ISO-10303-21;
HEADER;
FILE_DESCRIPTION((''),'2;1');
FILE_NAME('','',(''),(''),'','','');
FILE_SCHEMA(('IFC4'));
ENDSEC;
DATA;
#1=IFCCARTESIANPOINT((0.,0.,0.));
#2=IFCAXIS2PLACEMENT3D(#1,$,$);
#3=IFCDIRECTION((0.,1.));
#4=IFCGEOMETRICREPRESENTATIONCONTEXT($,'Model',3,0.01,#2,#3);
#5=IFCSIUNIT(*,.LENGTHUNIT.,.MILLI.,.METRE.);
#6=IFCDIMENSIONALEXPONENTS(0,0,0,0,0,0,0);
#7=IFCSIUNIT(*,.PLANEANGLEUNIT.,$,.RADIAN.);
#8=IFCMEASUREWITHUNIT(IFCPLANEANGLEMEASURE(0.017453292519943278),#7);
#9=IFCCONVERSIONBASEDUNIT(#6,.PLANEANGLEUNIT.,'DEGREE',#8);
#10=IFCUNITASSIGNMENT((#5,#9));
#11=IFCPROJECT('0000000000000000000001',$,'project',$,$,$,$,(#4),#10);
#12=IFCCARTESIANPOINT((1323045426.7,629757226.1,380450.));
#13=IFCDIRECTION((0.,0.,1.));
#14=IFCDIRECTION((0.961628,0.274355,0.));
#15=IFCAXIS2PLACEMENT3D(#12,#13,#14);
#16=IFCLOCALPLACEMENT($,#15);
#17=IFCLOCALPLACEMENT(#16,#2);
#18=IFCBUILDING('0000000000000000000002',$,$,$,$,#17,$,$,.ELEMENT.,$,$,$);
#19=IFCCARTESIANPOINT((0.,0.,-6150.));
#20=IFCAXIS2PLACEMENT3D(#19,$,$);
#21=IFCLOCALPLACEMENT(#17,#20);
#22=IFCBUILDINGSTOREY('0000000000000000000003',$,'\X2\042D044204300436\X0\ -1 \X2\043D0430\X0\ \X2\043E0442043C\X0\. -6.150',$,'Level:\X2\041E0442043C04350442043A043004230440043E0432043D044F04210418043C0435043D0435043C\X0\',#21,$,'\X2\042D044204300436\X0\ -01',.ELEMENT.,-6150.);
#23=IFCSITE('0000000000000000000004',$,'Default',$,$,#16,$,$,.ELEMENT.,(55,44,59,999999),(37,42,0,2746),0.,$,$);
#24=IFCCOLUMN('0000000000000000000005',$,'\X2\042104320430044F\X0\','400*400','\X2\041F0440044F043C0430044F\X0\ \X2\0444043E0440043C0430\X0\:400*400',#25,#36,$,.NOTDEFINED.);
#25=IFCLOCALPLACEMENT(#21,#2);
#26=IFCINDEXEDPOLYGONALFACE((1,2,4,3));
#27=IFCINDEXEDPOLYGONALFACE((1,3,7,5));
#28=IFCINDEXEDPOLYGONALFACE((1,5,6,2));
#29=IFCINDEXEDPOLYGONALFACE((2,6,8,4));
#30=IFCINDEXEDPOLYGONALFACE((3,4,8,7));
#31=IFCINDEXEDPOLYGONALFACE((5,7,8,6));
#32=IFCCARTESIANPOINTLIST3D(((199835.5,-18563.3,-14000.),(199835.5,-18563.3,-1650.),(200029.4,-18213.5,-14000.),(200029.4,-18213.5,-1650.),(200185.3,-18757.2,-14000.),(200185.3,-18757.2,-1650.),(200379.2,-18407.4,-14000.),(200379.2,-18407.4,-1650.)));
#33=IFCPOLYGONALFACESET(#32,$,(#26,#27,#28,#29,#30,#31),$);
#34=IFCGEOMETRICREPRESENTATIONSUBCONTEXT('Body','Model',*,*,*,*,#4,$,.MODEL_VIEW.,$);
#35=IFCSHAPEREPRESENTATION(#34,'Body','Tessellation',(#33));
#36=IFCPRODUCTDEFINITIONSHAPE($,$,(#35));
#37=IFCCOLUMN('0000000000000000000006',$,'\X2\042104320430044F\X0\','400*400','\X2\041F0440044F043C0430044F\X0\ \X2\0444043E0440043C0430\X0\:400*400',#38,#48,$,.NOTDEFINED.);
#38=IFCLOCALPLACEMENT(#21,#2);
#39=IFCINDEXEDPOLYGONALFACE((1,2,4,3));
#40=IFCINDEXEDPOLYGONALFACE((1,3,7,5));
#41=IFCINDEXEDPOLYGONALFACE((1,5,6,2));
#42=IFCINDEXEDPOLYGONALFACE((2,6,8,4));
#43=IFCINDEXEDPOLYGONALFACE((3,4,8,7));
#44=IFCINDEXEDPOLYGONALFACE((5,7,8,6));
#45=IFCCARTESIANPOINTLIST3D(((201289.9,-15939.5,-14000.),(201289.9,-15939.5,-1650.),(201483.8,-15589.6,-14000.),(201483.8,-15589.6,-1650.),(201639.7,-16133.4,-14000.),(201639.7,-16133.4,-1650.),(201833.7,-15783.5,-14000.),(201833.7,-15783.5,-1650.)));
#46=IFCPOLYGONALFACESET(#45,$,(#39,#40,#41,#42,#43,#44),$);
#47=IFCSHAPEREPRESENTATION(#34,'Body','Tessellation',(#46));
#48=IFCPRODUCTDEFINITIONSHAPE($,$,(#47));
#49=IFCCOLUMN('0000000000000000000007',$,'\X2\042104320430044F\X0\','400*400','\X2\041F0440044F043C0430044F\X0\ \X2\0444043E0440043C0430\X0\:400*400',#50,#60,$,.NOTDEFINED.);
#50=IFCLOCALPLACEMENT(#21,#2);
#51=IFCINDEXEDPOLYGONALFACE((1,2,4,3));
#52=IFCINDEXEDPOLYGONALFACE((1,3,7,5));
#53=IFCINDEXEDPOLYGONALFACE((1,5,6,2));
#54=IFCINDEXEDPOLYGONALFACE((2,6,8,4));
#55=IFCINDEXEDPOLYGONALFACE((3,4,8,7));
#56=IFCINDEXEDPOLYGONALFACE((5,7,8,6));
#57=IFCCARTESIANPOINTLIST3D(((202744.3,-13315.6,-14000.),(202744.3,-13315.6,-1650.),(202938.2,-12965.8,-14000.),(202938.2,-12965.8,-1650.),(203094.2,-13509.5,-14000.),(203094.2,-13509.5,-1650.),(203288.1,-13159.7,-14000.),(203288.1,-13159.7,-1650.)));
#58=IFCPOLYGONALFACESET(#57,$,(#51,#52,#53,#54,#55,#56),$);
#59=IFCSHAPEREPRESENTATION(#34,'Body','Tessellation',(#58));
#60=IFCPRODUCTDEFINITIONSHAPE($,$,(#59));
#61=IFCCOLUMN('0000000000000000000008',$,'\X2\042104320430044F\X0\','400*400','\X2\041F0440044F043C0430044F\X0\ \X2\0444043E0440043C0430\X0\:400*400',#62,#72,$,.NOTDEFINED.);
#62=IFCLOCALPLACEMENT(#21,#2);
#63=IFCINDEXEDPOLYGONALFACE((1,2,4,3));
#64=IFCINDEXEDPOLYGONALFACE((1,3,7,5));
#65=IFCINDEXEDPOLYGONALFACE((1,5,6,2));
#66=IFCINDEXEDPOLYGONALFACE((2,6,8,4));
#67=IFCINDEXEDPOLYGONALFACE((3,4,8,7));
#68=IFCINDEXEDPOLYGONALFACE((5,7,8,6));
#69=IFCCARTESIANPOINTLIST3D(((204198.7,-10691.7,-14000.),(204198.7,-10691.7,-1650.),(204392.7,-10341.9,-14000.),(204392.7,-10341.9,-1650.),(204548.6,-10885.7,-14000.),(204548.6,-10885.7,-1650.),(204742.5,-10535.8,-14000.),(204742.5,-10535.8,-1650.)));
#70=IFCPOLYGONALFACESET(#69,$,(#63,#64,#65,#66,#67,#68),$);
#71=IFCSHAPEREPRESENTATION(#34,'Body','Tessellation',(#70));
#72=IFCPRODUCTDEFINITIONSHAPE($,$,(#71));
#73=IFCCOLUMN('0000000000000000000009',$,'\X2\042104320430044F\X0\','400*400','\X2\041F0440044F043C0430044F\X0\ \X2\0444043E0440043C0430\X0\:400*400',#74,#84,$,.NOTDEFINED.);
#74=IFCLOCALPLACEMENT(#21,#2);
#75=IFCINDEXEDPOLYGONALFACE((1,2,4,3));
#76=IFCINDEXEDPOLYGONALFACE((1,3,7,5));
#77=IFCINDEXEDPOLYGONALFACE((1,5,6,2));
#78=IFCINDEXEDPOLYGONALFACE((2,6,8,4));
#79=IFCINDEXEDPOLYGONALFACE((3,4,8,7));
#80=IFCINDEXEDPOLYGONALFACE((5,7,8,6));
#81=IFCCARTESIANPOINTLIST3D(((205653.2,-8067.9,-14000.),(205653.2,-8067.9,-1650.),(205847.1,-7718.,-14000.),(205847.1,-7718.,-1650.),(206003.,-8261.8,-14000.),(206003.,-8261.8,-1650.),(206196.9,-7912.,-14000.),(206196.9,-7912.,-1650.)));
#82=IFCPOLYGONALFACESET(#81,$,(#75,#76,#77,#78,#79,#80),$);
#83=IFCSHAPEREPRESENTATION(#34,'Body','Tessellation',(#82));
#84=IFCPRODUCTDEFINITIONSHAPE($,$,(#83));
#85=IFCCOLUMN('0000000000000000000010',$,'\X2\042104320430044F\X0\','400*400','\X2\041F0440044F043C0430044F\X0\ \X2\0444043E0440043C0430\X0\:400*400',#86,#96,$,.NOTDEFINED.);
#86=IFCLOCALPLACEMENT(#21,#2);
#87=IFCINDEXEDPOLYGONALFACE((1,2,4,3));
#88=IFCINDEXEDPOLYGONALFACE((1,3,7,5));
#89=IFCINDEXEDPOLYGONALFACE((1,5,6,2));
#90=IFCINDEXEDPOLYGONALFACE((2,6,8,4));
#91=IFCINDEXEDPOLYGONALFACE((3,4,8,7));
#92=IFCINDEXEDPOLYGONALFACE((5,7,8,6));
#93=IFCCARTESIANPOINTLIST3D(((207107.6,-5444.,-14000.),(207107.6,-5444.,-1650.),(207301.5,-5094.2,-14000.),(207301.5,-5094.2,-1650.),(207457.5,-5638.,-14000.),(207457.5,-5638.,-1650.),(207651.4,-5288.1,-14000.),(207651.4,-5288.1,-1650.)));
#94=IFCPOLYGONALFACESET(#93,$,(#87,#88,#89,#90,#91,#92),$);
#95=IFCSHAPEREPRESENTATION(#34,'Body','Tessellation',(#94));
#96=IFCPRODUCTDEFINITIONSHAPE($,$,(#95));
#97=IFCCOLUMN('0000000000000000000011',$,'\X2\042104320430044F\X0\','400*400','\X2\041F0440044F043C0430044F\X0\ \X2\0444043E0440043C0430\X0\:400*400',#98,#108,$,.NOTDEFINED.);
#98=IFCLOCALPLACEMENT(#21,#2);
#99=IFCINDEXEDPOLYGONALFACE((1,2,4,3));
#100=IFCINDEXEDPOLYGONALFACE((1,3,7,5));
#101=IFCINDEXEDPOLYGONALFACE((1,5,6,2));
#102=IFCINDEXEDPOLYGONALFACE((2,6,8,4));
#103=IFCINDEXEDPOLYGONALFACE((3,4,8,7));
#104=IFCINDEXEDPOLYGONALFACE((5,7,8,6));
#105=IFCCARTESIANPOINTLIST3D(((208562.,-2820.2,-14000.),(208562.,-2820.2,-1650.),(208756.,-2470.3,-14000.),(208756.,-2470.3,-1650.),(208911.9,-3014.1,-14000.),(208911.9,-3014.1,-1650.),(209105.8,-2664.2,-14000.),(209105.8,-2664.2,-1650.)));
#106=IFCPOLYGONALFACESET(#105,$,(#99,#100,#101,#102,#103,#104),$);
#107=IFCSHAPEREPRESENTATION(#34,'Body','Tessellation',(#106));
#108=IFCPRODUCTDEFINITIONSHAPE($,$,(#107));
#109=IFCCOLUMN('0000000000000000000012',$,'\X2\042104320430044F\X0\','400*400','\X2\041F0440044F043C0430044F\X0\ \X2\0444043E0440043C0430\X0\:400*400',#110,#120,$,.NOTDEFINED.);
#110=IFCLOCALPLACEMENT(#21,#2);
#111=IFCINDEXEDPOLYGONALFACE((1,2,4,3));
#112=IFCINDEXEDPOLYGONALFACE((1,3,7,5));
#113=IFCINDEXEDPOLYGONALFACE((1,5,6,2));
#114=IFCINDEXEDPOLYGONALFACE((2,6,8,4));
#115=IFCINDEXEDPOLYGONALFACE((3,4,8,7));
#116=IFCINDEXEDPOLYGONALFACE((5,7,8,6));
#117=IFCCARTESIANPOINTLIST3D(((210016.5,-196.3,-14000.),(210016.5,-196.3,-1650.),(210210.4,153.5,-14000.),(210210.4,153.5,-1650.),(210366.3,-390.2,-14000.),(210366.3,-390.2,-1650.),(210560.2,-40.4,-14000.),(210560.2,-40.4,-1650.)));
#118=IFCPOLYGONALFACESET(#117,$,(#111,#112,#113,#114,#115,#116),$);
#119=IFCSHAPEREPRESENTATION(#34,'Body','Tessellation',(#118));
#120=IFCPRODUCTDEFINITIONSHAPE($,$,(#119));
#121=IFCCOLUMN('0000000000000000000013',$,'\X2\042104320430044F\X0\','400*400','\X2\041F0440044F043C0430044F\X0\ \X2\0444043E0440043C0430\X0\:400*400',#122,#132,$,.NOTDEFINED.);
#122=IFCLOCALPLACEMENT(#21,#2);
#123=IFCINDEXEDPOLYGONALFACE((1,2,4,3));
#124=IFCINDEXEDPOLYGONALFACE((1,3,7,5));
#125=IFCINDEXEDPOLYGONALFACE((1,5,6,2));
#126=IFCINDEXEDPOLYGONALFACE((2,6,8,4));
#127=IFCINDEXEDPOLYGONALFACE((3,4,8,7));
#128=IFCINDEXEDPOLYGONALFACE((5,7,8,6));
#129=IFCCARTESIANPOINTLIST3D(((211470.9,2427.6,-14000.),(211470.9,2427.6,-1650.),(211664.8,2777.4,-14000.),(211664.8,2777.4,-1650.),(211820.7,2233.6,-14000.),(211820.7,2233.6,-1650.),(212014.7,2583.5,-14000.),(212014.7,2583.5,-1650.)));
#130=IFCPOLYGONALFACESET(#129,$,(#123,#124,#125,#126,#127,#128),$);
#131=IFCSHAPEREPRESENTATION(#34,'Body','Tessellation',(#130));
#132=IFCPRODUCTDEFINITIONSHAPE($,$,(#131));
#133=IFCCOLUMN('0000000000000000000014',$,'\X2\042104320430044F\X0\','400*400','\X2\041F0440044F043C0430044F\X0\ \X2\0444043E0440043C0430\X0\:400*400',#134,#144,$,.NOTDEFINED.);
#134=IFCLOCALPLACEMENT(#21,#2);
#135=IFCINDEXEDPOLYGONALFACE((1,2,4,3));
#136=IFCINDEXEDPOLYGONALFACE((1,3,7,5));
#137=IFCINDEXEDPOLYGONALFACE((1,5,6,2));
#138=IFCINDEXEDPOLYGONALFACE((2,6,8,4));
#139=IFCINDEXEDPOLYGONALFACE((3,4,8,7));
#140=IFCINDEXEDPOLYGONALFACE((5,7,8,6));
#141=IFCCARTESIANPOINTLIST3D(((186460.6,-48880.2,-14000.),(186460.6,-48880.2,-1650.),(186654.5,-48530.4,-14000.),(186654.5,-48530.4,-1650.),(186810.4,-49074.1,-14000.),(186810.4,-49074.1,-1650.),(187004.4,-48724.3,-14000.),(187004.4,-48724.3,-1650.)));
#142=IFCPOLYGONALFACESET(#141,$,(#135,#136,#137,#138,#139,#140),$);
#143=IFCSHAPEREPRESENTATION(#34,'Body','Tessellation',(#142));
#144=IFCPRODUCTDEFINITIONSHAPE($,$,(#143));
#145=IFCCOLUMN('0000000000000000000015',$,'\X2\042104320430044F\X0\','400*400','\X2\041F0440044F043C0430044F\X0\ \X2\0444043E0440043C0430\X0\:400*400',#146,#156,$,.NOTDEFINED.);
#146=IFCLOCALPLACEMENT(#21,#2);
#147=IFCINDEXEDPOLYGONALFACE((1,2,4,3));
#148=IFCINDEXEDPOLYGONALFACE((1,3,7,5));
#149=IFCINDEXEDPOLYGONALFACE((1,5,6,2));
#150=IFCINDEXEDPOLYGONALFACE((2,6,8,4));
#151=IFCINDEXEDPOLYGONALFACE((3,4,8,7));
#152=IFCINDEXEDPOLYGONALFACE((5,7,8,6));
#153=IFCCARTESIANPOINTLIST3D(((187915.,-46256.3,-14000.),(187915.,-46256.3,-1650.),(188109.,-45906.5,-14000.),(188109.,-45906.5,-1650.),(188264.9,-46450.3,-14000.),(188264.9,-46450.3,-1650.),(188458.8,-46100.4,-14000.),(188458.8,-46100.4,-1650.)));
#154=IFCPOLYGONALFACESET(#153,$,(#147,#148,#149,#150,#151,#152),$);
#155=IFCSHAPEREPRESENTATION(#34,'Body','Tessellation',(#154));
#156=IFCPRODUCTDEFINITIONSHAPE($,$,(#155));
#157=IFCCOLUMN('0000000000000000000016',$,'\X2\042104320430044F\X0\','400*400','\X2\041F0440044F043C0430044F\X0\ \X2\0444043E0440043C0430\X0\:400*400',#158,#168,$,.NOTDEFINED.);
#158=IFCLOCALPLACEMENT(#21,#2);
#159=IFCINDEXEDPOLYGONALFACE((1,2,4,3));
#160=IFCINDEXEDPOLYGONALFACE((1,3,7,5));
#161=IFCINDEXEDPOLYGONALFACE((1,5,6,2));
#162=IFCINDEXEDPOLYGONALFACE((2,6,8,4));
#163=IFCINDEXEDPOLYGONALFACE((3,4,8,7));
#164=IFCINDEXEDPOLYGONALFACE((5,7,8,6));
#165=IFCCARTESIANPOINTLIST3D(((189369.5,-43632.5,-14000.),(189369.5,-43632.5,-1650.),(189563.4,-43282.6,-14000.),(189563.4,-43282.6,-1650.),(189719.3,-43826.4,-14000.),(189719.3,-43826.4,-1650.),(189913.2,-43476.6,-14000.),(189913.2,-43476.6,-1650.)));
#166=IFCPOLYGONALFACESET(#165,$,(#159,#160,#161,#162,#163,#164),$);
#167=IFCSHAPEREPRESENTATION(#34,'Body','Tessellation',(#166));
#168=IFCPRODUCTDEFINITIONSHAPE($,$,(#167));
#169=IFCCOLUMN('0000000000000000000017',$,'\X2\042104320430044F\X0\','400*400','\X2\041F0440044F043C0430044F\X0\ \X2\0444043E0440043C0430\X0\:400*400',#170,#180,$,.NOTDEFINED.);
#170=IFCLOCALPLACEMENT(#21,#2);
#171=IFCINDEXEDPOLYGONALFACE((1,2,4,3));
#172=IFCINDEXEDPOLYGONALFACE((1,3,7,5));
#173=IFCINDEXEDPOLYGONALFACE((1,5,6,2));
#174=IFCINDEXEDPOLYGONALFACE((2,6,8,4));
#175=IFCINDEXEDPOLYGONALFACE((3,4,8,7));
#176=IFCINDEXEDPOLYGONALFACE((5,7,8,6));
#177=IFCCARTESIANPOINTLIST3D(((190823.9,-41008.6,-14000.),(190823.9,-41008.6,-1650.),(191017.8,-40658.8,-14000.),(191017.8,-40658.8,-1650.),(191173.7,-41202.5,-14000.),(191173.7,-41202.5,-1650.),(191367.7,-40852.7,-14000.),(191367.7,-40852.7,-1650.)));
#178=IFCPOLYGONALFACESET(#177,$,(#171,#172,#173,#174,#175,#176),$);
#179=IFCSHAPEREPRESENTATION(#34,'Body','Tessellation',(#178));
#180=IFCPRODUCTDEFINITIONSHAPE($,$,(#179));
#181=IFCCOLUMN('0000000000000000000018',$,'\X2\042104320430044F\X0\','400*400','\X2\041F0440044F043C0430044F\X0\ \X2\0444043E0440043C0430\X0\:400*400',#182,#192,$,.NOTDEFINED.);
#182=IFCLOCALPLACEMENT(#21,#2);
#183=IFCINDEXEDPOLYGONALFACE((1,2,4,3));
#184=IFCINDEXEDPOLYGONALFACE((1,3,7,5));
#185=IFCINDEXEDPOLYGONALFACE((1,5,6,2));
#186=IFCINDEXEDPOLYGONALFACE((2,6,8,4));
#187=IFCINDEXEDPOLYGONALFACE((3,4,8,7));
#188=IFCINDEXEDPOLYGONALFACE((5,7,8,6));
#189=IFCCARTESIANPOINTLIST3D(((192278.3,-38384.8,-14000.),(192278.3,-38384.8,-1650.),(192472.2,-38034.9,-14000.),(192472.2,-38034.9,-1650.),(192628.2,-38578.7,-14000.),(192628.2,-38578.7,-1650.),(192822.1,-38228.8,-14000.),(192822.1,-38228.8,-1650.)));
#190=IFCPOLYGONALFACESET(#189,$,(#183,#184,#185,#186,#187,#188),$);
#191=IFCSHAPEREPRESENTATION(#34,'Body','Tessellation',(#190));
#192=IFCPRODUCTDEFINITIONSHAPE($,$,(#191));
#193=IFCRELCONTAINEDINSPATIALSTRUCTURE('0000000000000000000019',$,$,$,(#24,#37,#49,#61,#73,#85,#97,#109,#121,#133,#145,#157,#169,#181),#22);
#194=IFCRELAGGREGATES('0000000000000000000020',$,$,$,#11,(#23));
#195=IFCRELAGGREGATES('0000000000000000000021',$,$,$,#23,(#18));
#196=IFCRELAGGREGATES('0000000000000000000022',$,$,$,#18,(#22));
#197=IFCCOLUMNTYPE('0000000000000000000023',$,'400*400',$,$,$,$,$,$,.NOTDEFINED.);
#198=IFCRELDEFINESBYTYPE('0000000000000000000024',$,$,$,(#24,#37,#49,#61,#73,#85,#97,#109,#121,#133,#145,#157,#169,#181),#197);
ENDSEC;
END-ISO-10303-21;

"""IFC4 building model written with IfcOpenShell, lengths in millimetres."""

from ifc_helpers import new_model, entity, si_unit, converted_unit, direction, frame, origin, place, context, subcontext, project, spatial, indexed_curve, outline, extrude, type_object, element, save


model = new_model("IFC4")

# Units and contexts
model_context = context("Model", 3, precision=0.01, world=origin(), true_north=direction((0.0, 1.0)))
body_context = subcontext(model_context, "Body", "Model", "MODEL_VIEW")
ifc_project = project(units=[si_unit("LENGTHUNIT", "METRE", prefix="MILLI"), converted_unit("PLANEANGLEUNIT", "DEGREE", entity("IfcPlaneAngleMeasure", 0.017453292519943278), si_unit("PLANEANGLEUNIT", "RADIAN"), dimensions=[0, 0, 0, 0, 0, 0, 0])], contexts=[model_context])

# Site, building, storey
site_placement = place(None, frame((1323045426.7, 629757226.1, 380450.0), z_axis=(0.0, 0.0, 1.0), x_axis=(0.961628, 0.274355, 0.0)))
site = spatial("IfcSite", under=ifc_project, at=site_placement, Name="Default", CompositionType="ELEMENT", RefLatitude=(55, 44, 59, 999999), RefLongitude=(37, 42, 0, 2746), RefElevation=0.0)
building_placement = place(site_placement, origin())
building = spatial("IfcBuilding", under=site, at=building_placement, CompositionType="ELEMENT")
storey_placement = place(building_placement, frame((0.0, 0.0, -6150.0)))
storey = spatial("IfcBuildingStorey", under=building, at=storey_placement, Name="Этаж -1 на отм. -6.150", ObjectType="Level:ОтметкаУровняСИменем", LongName="Этаж -01", CompositionType="ELEMENT", Elevation=-6150.0)

# Columns
column_type = type_object("IfcColumnType", Name="400*400", PredefinedType="NOTDEFINED")
column_1_placement = place(storey_placement, origin())
element("IfcColumn", 1, at=column_1_placement, inside=storey, type_object=column_type, Name="Свая", Description="400*400", ObjectType="Прямая форма:400*400", PredefinedType="NOTDEFINED", context=body_context, shape_type="SweptSolid", body=[
    extrude(outline(indexed_curve([(-200.0, -200.0), (200.0, -200.0), (200.0, 200.0), (-200.0, 200.0), (-200.0, -200.0)], self_intersect=False)), frame((200107.3, -18485.4, -14000.0), z_axis=(0.0, 0.0, 1.0), x_axis=(0.48481, 0.87462, 0.0)), (0.0, 0.0, 1.0), 12350.0),
])
column_2_placement = place(storey_placement, origin())
element("IfcColumn", 2, at=column_2_placement, inside=storey, type_object=column_type, Name="Свая", Description="400*400", ObjectType="Прямая форма:400*400", PredefinedType="NOTDEFINED", context=body_context, shape_type="SweptSolid", body=[
    extrude(outline(indexed_curve([(-200.0, -200.0), (200.0, -200.0), (200.0, 200.0), (-200.0, 200.0), (-200.0, -200.0)], self_intersect=False)), frame((201561.8, -15861.5, -14000.0), z_axis=(0.0, 0.0, 1.0), x_axis=(0.48481, 0.87462, 0.0)), (0.0, 0.0, 1.0), 12350.0),
])
column_3_placement = place(storey_placement, origin())
element("IfcColumn", 3, at=column_3_placement, inside=storey, type_object=column_type, Name="Свая", Description="400*400", ObjectType="Прямая форма:400*400", PredefinedType="NOTDEFINED", context=body_context, shape_type="SweptSolid", body=[
    extrude(outline(indexed_curve([(-200.0, -200.0), (200.0, -200.0), (200.0, 200.0), (-200.0, 200.0), (-200.0, -200.0)], self_intersect=False)), frame((203016.2, -13237.6, -14000.0), z_axis=(0.0, 0.0, 1.0), x_axis=(0.48481, 0.87462, 0.0)), (0.0, 0.0, 1.0), 12350.0),
])
column_4_placement = place(storey_placement, origin())
element("IfcColumn", 4, at=column_4_placement, inside=storey, type_object=column_type, Name="Свая", Description="400*400", ObjectType="Прямая форма:400*400", PredefinedType="NOTDEFINED", context=body_context, shape_type="SweptSolid", body=[
    extrude(outline(indexed_curve([(-200.0, -200.0), (200.0, -200.0), (200.0, 200.0), (-200.0, 200.0), (-200.0, -200.0)], self_intersect=False)), frame((204470.6, -10613.8, -14000.0), z_axis=(0.0, 0.0, 1.0), x_axis=(0.48481, 0.87462, 0.0)), (0.0, 0.0, 1.0), 12350.0),
])
column_5_placement = place(storey_placement, origin())
element("IfcColumn", 5, at=column_5_placement, inside=storey, type_object=column_type, Name="Свая", Description="400*400", ObjectType="Прямая форма:400*400", PredefinedType="NOTDEFINED", context=body_context, shape_type="SweptSolid", body=[
    extrude(outline(indexed_curve([(-200.0, -200.0), (200.0, -200.0), (200.0, 200.0), (-200.0, 200.0), (-200.0, -200.0)], self_intersect=False)), frame((205925.1, -7989.9, -14000.0), z_axis=(0.0, 0.0, 1.0), x_axis=(0.48481, 0.87462, 0.0)), (0.0, 0.0, 1.0), 12350.0),
])
column_6_placement = place(storey_placement, origin())
element("IfcColumn", 6, at=column_6_placement, inside=storey, type_object=column_type, Name="Свая", Description="400*400", ObjectType="Прямая форма:400*400", PredefinedType="NOTDEFINED", context=body_context, shape_type="SweptSolid", body=[
    extrude(outline(indexed_curve([(-200.0, -200.0), (200.0, -200.0), (200.0, 200.0), (-200.0, 200.0), (-200.0, -200.0)], self_intersect=False)), frame((207379.5, -5366.1, -14000.0), z_axis=(0.0, 0.0, 1.0), x_axis=(0.48481, 0.87462, 0.0)), (0.0, 0.0, 1.0), 12350.0),
])
column_7_placement = place(storey_placement, origin())
element("IfcColumn", 7, at=column_7_placement, inside=storey, type_object=column_type, Name="Свая", Description="400*400", ObjectType="Прямая форма:400*400", PredefinedType="NOTDEFINED", context=body_context, shape_type="SweptSolid", body=[
    extrude(outline(indexed_curve([(-200.0, -200.0), (200.0, -200.0), (200.0, 200.0), (-200.0, 200.0), (-200.0, -200.0)], self_intersect=False)), frame((208833.9, -2742.2, -14000.0), z_axis=(0.0, 0.0, 1.0), x_axis=(0.48481, 0.87462, 0.0)), (0.0, 0.0, 1.0), 12350.0),
])
column_8_placement = place(storey_placement, origin())
element("IfcColumn", 8, at=column_8_placement, inside=storey, type_object=column_type, Name="Свая", Description="400*400", ObjectType="Прямая форма:400*400", PredefinedType="NOTDEFINED", context=body_context, shape_type="SweptSolid", body=[
    extrude(outline(indexed_curve([(-200.0, -200.0), (200.0, -200.0), (200.0, 200.0), (-200.0, 200.0), (-200.0, -200.0)], self_intersect=False)), frame((210288.4, -118.3, -14000.0), z_axis=(0.0, 0.0, 1.0), x_axis=(0.48481, 0.87462, 0.0)), (0.0, 0.0, 1.0), 12350.0),
])
column_9_placement = place(storey_placement, origin())
element("IfcColumn", 9, at=column_9_placement, inside=storey, type_object=column_type, Name="Свая", Description="400*400", ObjectType="Прямая форма:400*400", PredefinedType="NOTDEFINED", context=body_context, shape_type="SweptSolid", body=[
    extrude(outline(indexed_curve([(-200.0, -200.0), (200.0, -200.0), (200.0, 200.0), (-200.0, 200.0), (-200.0, -200.0)], self_intersect=False)), frame((211742.8, 2505.5, -14000.0), z_axis=(0.0, 0.0, 1.0), x_axis=(0.48481, 0.87462, 0.0)), (0.0, 0.0, 1.0), 12350.0),
])
column_10_placement = place(storey_placement, origin())
element("IfcColumn", 10, at=column_10_placement, inside=storey, type_object=column_type, Name="Свая", Description="400*400", ObjectType="Прямая форма:400*400", PredefinedType="NOTDEFINED", context=body_context, shape_type="SweptSolid", body=[
    extrude(outline(indexed_curve([(-200.0, -200.0), (200.0, -200.0), (200.0, 200.0), (-200.0, 200.0), (-200.0, -200.0)], self_intersect=False)), frame((186732.5, -48802.2, -14000.0), z_axis=(0.0, 0.0, 1.0), x_axis=(0.48481, 0.87462, 0.0)), (0.0, 0.0, 1.0), 12350.0),
])
column_11_placement = place(storey_placement, origin())
element("IfcColumn", 11, at=column_11_placement, inside=storey, type_object=column_type, Name="Свая", Description="400*400", ObjectType="Прямая форма:400*400", PredefinedType="NOTDEFINED", context=body_context, shape_type="SweptSolid", body=[
    extrude(outline(indexed_curve([(-200.0, -200.0), (200.0, -200.0), (200.0, 200.0), (-200.0, 200.0), (-200.0, -200.0)], self_intersect=False)), frame((188186.9, -46178.4, -14000.0), z_axis=(0.0, 0.0, 1.0), x_axis=(0.48481, 0.87462, 0.0)), (0.0, 0.0, 1.0), 12350.0),
])
column_12_placement = place(storey_placement, origin())
element("IfcColumn", 12, at=column_12_placement, inside=storey, type_object=column_type, Name="Свая", Description="400*400", ObjectType="Прямая форма:400*400", PredefinedType="NOTDEFINED", context=body_context, shape_type="SweptSolid", body=[
    extrude(outline(indexed_curve([(-200.0, -200.0), (200.0, -200.0), (200.0, 200.0), (-200.0, 200.0), (-200.0, -200.0)], self_intersect=False)), frame((189641.3, -43554.5, -14000.0), z_axis=(0.0, 0.0, 1.0), x_axis=(0.48481, 0.87462, 0.0)), (0.0, 0.0, 1.0), 12350.0),
])
column_13_placement = place(storey_placement, origin())
element("IfcColumn", 13, at=column_13_placement, inside=storey, type_object=column_type, Name="Свая", Description="400*400", ObjectType="Прямая форма:400*400", PredefinedType="NOTDEFINED", context=body_context, shape_type="SweptSolid", body=[
    extrude(outline(indexed_curve([(-200.0, -200.0), (200.0, -200.0), (200.0, 200.0), (-200.0, 200.0), (-200.0, -200.0)], self_intersect=False)), frame((191095.8, -40930.7, -14000.0), z_axis=(0.0, 0.0, 1.0), x_axis=(0.48481, 0.87462, 0.0)), (0.0, 0.0, 1.0), 12350.0),
])
column_14_placement = place(storey_placement, origin())
element("IfcColumn", 14, at=column_14_placement, inside=storey, type_object=column_type, Name="Свая", Description="400*400", ObjectType="Прямая форма:400*400", PredefinedType="NOTDEFINED", context=body_context, shape_type="SweptSolid", body=[
    extrude(outline(indexed_curve([(-200.0, -200.0), (200.0, -200.0), (200.0, 200.0), (-200.0, 200.0), (-200.0, -200.0)], self_intersect=False)), frame((192550.2, -38306.8, -14000.0), z_axis=(0.0, 0.0, 1.0), x_axis=(0.48481, 0.87462, 0.0)), (0.0, 0.0, 1.0), 12350.0),
])

save(model, "model.ifc")
